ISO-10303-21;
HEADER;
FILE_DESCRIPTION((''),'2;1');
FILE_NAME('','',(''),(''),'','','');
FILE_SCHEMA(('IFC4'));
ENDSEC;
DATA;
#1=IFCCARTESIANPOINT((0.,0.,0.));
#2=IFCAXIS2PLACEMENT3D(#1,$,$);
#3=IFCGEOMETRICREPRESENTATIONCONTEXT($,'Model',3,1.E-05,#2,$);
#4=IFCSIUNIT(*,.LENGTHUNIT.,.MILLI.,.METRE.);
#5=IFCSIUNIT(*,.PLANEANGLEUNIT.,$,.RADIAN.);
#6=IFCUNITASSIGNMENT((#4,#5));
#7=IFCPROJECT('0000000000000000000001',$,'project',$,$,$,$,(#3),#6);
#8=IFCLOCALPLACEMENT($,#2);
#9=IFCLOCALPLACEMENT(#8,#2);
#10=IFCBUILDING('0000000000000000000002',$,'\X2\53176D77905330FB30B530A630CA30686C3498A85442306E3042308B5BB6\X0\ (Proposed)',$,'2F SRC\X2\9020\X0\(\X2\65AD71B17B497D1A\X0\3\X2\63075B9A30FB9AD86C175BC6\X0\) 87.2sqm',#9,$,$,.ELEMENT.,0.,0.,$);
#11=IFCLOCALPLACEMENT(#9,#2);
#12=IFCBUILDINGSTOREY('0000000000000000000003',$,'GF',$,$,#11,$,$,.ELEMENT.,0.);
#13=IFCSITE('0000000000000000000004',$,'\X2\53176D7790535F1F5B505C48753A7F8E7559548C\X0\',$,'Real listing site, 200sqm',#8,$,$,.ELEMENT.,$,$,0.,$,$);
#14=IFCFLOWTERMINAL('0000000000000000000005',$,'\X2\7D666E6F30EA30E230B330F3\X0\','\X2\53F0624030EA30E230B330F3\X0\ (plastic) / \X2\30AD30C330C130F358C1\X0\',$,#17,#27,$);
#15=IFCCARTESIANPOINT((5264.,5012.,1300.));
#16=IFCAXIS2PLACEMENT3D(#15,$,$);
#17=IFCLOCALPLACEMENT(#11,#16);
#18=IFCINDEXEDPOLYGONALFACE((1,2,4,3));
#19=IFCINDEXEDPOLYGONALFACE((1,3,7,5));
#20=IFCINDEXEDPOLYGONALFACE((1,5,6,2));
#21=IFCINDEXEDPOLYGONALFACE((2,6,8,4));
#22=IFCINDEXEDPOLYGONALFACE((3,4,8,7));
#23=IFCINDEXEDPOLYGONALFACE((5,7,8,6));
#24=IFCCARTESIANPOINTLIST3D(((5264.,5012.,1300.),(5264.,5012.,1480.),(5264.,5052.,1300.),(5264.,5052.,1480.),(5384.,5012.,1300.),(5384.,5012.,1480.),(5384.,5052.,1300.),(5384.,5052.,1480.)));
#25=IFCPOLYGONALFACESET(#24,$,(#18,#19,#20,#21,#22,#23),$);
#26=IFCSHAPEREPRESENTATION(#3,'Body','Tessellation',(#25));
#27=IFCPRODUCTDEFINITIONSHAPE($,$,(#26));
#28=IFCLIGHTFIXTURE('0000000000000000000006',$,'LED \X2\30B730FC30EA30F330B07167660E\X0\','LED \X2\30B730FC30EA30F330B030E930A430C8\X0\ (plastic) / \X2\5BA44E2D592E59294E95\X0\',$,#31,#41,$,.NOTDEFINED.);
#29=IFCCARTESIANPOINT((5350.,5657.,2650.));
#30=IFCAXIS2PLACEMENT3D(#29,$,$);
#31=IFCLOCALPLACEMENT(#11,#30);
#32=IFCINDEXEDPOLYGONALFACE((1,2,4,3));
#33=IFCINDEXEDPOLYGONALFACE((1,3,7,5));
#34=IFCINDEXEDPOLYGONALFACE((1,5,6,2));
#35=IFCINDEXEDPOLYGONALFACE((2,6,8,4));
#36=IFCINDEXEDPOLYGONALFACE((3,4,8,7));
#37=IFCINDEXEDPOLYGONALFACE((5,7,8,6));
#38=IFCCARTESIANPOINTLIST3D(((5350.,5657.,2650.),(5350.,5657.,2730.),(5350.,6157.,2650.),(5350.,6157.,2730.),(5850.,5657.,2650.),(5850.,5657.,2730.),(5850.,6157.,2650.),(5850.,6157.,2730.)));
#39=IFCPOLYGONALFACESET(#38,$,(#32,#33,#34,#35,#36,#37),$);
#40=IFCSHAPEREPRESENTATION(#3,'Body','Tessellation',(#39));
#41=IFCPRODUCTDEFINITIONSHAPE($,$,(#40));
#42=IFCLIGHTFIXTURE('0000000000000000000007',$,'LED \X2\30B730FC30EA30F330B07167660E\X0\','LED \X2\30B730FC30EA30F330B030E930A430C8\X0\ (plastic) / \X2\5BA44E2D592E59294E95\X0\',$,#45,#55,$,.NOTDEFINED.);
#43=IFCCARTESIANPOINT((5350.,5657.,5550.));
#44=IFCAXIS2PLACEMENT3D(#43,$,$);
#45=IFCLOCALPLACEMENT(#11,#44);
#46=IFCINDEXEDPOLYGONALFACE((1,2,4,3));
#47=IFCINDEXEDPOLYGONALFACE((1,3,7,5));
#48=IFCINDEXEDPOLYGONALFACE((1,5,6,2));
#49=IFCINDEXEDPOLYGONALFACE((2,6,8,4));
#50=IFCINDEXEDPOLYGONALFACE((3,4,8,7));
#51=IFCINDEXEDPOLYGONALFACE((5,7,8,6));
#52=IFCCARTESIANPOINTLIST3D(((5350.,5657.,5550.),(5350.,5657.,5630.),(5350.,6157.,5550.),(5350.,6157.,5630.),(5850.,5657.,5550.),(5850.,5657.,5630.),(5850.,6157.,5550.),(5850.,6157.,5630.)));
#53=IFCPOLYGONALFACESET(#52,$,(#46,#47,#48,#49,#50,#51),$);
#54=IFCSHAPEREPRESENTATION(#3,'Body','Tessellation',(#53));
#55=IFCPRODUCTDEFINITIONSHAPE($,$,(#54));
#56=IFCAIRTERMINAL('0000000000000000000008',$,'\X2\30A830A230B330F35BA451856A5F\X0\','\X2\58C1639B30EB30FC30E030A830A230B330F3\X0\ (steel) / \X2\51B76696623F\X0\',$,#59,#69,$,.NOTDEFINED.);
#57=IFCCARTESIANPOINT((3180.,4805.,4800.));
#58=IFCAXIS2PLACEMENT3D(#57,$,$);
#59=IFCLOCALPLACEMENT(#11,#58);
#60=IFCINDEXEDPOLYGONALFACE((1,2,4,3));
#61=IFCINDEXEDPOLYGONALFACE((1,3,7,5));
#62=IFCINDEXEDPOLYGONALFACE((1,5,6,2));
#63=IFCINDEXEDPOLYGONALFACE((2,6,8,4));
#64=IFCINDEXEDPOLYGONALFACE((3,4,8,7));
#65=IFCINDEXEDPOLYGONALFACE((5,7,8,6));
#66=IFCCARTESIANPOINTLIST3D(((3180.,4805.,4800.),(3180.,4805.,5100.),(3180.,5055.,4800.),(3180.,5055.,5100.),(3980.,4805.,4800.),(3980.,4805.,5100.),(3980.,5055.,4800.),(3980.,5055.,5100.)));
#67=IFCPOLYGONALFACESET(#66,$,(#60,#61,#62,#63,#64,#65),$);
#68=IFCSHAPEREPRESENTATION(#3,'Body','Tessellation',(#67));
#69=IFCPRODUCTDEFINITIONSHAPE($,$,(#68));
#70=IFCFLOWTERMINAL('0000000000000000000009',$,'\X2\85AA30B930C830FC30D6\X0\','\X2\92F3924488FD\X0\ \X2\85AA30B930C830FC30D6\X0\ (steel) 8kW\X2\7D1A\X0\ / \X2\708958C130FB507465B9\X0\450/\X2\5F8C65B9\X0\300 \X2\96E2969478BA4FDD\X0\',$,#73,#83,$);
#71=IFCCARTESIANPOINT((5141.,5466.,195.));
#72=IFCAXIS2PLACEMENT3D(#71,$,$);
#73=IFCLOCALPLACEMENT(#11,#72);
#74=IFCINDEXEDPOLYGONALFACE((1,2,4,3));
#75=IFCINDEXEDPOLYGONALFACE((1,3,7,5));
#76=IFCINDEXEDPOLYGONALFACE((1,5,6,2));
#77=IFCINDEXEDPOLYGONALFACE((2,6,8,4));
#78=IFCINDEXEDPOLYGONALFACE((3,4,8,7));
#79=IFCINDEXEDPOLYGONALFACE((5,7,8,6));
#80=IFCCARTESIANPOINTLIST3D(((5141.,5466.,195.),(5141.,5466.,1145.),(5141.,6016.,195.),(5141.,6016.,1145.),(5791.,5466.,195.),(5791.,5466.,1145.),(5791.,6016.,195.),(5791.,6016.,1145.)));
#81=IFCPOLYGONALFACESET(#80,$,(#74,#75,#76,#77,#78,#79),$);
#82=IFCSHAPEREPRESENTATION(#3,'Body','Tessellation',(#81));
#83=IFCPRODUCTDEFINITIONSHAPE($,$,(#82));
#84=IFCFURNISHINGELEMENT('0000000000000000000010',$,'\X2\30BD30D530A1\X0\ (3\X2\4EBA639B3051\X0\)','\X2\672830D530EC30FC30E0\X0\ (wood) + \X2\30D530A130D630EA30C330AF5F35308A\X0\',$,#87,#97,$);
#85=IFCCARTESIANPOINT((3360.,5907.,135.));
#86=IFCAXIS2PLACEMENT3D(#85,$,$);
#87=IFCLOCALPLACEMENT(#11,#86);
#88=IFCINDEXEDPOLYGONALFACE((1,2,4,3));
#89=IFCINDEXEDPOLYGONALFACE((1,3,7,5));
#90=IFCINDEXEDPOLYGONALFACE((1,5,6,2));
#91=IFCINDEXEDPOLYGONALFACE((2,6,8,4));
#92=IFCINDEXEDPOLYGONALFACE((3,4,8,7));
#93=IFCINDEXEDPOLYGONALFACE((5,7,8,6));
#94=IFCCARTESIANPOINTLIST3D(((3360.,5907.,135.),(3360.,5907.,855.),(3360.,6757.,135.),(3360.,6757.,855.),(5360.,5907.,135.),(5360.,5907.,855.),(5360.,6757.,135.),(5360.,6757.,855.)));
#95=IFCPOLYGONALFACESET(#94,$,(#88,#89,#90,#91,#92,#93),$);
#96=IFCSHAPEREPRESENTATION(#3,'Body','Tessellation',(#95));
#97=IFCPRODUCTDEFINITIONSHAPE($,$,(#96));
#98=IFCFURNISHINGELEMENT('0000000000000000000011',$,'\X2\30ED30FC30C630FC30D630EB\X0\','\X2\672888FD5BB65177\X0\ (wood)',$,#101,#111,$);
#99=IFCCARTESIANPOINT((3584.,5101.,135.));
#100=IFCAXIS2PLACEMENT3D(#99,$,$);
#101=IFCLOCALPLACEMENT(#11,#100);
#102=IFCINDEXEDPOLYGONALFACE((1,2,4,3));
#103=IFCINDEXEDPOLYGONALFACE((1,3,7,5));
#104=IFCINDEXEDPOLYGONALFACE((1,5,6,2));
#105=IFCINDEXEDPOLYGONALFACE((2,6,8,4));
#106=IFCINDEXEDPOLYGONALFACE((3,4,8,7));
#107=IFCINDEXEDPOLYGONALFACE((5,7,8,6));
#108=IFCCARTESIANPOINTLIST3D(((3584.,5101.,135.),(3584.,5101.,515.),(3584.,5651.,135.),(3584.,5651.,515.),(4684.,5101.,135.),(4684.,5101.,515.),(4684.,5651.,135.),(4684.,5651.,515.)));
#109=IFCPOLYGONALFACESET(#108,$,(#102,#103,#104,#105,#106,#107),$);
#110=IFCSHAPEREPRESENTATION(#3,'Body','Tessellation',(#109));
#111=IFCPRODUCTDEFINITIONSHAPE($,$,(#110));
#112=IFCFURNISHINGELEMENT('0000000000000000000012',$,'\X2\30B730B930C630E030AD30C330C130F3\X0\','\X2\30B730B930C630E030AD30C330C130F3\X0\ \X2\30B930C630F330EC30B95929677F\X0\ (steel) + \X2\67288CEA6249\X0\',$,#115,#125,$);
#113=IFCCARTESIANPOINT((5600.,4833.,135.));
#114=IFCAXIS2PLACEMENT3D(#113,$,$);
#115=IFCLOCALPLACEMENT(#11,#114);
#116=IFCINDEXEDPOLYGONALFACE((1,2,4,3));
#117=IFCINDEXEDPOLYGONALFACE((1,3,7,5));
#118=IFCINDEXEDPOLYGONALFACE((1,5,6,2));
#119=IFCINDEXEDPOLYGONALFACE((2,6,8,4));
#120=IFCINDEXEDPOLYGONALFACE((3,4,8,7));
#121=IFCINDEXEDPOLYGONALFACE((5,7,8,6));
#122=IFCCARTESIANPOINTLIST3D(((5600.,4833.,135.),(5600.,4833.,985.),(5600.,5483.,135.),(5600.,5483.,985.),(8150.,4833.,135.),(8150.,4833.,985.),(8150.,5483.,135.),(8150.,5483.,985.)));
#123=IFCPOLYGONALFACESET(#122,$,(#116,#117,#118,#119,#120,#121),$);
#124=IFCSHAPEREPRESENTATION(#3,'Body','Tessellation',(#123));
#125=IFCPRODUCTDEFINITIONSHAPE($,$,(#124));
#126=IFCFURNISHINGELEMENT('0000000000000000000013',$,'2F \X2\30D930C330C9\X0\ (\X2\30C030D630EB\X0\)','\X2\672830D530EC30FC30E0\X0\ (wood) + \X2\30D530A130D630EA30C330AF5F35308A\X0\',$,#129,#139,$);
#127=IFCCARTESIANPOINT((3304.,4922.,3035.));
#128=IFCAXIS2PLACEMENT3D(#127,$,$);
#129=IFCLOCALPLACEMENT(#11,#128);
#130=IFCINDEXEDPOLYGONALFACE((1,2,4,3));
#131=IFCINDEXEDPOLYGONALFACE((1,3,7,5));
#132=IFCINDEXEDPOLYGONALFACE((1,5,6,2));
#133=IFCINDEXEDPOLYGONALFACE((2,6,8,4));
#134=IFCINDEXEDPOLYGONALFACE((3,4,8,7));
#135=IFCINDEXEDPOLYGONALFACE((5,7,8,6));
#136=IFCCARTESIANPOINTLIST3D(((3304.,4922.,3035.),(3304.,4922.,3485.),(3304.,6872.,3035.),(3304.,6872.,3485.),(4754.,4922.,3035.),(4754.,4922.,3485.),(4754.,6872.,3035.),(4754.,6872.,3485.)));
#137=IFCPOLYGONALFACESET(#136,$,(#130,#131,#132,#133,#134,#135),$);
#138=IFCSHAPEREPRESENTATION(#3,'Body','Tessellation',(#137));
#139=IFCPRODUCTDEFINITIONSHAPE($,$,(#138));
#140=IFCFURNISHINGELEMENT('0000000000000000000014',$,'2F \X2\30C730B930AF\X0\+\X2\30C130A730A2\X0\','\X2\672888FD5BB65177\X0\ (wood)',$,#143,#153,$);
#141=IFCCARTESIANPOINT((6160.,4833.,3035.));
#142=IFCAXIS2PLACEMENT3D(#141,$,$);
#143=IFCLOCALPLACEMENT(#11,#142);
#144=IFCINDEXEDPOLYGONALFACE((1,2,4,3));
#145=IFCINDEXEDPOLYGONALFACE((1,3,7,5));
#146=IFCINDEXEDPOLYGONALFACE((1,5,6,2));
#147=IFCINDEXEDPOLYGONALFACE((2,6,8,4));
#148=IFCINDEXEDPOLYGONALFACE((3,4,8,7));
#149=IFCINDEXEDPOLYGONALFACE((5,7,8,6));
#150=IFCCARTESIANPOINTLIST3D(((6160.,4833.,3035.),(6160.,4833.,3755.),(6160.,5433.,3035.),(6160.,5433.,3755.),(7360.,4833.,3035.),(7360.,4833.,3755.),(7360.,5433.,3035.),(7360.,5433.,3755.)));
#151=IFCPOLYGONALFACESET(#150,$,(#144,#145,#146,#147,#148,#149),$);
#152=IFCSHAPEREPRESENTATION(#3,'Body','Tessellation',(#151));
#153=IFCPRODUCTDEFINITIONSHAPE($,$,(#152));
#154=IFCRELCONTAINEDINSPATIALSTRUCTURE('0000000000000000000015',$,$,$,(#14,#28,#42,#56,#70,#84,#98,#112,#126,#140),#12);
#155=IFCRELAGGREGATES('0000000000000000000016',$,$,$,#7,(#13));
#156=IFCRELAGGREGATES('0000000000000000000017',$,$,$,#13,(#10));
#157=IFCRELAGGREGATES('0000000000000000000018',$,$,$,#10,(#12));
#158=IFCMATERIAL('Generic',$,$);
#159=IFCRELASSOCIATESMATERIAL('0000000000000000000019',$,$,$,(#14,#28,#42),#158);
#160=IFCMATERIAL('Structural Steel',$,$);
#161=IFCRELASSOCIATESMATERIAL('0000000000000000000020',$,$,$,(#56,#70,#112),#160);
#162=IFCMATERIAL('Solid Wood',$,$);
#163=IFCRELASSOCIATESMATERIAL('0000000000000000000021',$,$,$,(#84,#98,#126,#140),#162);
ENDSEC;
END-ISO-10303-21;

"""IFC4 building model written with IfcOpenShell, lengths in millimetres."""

from ifc_helpers import new_model, si_unit, frame, frame_2d, origin, place, context, project, spatial, rectangle, extrude, material, element, save


model = new_model("IFC4")

# Units and contexts
model_context = context("Model", 3, precision=1e-05, world=origin())
ifc_project = project(units=[si_unit("LENGTHUNIT", "METRE", prefix="MILLI"), si_unit("PLANEANGLEUNIT", "RADIAN")], contexts=[model_context])

# Site, building, storey
site_placement = place(None, origin())
site = spatial("IfcSite", under=ifc_project, at=site_placement, Name="北海道弟子屈町美留和", ObjectType="Real listing site, 200sqm", CompositionType="ELEMENT", RefElevation=0.0)
building_placement = place(site_placement, origin())
building = spatial("IfcBuilding", under=site, at=building_placement, Name="北海道・サウナと水風呂のある家 (Proposed)", ObjectType="2F SRC造(断熱等級3指定・高気密) 87.2sqm", CompositionType="ELEMENT", ElevationOfRefHeight=0.0, ElevationOfTerrain=0.0)
storey_placement = place(building_placement, origin())
storey = spatial("IfcBuildingStorey", under=building, at=storey_placement, Name="GF", CompositionType="ELEMENT", Elevation=0.0)

# Shared definitions
ifc_material_1 = material(Name="Solid Wood")

# Shared definitions
ifc_material_2 = material(Name="Structural Steel")

# Shared definitions
ifc_material_3 = material(Name="Generic")

# Flow terminal
flow_terminal_1_placement = place(storey_placement, frame((5264.0, 5012.0, 1300.0)))
element("IfcFlowTerminal", 1, at=flow_terminal_1_placement, inside=storey, material=ifc_material_3, Name="給湯リモコン", Description="台所リモコン (plastic) / キッチン壁", context=model_context, shape_type="SweptSolid", body=[
    extrude(rectangle(XDim=120.0, YDim=40.0, at=frame_2d((60.0, 20.0))), frame((5264.0, 5012.0, 1300.0)), (0.0, 0.0, 1.0), 180.0),
])

# Light fixtures
light_fixture_1_placement = place(storey_placement, frame((5350.0, 5657.0, 2650.0)))
element("IfcLightFixture", 2, at=light_fixture_1_placement, inside=storey, material=ifc_material_3, Name="LED シーリング照明", Description="LED シーリングライト (plastic) / 室中央天井", PredefinedType="NOTDEFINED", context=model_context, shape_type="SweptSolid", body=[
    extrude(rectangle(XDim=500.0, YDim=500.0, at=frame_2d((250.0, 250.0))), frame((5350.0, 5657.0, 2650.0)), (0.0, 0.0, 1.0), 80.0),
])
light_fixture_2_placement = place(storey_placement, frame((5350.0, 5657.0, 5550.0)))
element("IfcLightFixture", 3, at=light_fixture_2_placement, inside=storey, material=ifc_material_3, Name="LED シーリング照明", Description="LED シーリングライト (plastic) / 室中央天井", PredefinedType="NOTDEFINED", context=model_context, shape_type="SweptSolid", body=[
    extrude(rectangle(XDim=500.0, YDim=500.0, at=frame_2d((250.0, 250.0))), frame((5350.0, 5657.0, 5550.0)), (0.0, 0.0, 1.0), 80.0),
])

# Air terminal
air_terminal_placement = place(storey_placement, frame((3180.0, 4805.0, 4800.0)))
element("IfcAirTerminal", 4, at=air_terminal_placement, inside=storey, material=ifc_material_2, Name="エアコン室内機", Description="壁掛ルームエアコン (steel) / 冷暖房", PredefinedType="NOTDEFINED", context=model_context, shape_type="SweptSolid", body=[
    extrude(rectangle(XDim=800.0, YDim=250.0, at=frame_2d((400.0, 125.0))), frame((3180.0, 4805.0, 4800.0)), (0.0, 0.0, 1.0), 300.0),
])

# Flow terminal
flow_terminal_2_placement = place(storey_placement, frame((5141.0, 5466.0, 195.0)))
element("IfcFlowTerminal", 5, at=flow_terminal_2_placement, inside=storey, material=ifc_material_2, Name="薪ストーブ", Description="鋳鉄製 薪ストーブ (steel) 8kW級 / 炉壁・側方450/後方300 離隔確保", context=model_context, shape_type="SweptSolid", body=[
    extrude(rectangle(XDim=650.0, YDim=550.0, at=frame_2d((325.0, 275.0))), frame((5141.0, 5466.0, 195.0)), (0.0, 0.0, 1.0), 950.0),
])

# Furnishing elements
furnishing_1_placement = place(storey_placement, frame((3360.0, 5907.0, 135.0)))
element("IfcFurnishingElement", 6, at=furnishing_1_placement, inside=storey, material=ifc_material_1, Name="ソファ (3人掛け)", Description="木フレーム (wood) + ファブリック張り", context=model_context, shape_type="SweptSolid", body=[
    extrude(rectangle(XDim=2000.0, YDim=850.0, at=frame_2d((1000.0, 425.0))), frame((3360.0, 5907.0, 135.0)), (0.0, 0.0, 1.0), 720.0),
])
furnishing_2_placement = place(storey_placement, frame((3584.0, 5101.0, 135.0)))
element("IfcFurnishingElement", 7, at=furnishing_2_placement, inside=storey, material=ifc_material_1, Name="ローテーブル", Description="木製家具 (wood)", context=model_context, shape_type="SweptSolid", body=[
    extrude(rectangle(XDim=1100.0, YDim=550.0, at=frame_2d((550.0, 275.0))), frame((3584.0, 5101.0, 135.0)), (0.0, 0.0, 1.0), 380.0),
])
furnishing_3_placement = place(storey_placement, frame((5600.0, 4833.0, 135.0)))
element("IfcFurnishingElement", 8, at=furnishing_3_placement, inside=storey, material=ifc_material_2, Name="システムキッチン", Description="システムキッチン ステンレス天板 (steel) + 木質扉", context=model_context, shape_type="SweptSolid", body=[
    extrude(rectangle(XDim=2550.0, YDim=650.0, at=frame_2d((1275.0, 325.0))), frame((5600.0, 4833.0, 135.0)), (0.0, 0.0, 1.0), 850.0),
])
furnishing_4_placement = place(storey_placement, frame((3304.0, 4922.0, 3035.0)))
element("IfcFurnishingElement", 9, at=furnishing_4_placement, inside=storey, material=ifc_material_1, Name="2F ベッド (ダブル)", Description="木フレーム (wood) + ファブリック張り", context=model_context, shape_type="SweptSolid", body=[
    extrude(rectangle(XDim=1450.0, YDim=1950.0, at=frame_2d((725.0, 975.0))), frame((3304.0, 4922.0, 3035.0)), (0.0, 0.0, 1.0), 450.0),
])
furnishing_5_placement = place(storey_placement, frame((6160.0, 4833.0, 3035.0)))
element("IfcFurnishingElement", 10, at=furnishing_5_placement, inside=storey, material=ifc_material_1, Name="2F デスク+チェア", Description="木製家具 (wood)", context=model_context, shape_type="SweptSolid", body=[
    extrude(rectangle(XDim=1200.0, YDim=600.0, at=frame_2d((600.0, 300.0))), frame((6160.0, 4833.0, 3035.0)), (0.0, 0.0, 1.0), 720.0),
])

save(model, "model.ifc")
